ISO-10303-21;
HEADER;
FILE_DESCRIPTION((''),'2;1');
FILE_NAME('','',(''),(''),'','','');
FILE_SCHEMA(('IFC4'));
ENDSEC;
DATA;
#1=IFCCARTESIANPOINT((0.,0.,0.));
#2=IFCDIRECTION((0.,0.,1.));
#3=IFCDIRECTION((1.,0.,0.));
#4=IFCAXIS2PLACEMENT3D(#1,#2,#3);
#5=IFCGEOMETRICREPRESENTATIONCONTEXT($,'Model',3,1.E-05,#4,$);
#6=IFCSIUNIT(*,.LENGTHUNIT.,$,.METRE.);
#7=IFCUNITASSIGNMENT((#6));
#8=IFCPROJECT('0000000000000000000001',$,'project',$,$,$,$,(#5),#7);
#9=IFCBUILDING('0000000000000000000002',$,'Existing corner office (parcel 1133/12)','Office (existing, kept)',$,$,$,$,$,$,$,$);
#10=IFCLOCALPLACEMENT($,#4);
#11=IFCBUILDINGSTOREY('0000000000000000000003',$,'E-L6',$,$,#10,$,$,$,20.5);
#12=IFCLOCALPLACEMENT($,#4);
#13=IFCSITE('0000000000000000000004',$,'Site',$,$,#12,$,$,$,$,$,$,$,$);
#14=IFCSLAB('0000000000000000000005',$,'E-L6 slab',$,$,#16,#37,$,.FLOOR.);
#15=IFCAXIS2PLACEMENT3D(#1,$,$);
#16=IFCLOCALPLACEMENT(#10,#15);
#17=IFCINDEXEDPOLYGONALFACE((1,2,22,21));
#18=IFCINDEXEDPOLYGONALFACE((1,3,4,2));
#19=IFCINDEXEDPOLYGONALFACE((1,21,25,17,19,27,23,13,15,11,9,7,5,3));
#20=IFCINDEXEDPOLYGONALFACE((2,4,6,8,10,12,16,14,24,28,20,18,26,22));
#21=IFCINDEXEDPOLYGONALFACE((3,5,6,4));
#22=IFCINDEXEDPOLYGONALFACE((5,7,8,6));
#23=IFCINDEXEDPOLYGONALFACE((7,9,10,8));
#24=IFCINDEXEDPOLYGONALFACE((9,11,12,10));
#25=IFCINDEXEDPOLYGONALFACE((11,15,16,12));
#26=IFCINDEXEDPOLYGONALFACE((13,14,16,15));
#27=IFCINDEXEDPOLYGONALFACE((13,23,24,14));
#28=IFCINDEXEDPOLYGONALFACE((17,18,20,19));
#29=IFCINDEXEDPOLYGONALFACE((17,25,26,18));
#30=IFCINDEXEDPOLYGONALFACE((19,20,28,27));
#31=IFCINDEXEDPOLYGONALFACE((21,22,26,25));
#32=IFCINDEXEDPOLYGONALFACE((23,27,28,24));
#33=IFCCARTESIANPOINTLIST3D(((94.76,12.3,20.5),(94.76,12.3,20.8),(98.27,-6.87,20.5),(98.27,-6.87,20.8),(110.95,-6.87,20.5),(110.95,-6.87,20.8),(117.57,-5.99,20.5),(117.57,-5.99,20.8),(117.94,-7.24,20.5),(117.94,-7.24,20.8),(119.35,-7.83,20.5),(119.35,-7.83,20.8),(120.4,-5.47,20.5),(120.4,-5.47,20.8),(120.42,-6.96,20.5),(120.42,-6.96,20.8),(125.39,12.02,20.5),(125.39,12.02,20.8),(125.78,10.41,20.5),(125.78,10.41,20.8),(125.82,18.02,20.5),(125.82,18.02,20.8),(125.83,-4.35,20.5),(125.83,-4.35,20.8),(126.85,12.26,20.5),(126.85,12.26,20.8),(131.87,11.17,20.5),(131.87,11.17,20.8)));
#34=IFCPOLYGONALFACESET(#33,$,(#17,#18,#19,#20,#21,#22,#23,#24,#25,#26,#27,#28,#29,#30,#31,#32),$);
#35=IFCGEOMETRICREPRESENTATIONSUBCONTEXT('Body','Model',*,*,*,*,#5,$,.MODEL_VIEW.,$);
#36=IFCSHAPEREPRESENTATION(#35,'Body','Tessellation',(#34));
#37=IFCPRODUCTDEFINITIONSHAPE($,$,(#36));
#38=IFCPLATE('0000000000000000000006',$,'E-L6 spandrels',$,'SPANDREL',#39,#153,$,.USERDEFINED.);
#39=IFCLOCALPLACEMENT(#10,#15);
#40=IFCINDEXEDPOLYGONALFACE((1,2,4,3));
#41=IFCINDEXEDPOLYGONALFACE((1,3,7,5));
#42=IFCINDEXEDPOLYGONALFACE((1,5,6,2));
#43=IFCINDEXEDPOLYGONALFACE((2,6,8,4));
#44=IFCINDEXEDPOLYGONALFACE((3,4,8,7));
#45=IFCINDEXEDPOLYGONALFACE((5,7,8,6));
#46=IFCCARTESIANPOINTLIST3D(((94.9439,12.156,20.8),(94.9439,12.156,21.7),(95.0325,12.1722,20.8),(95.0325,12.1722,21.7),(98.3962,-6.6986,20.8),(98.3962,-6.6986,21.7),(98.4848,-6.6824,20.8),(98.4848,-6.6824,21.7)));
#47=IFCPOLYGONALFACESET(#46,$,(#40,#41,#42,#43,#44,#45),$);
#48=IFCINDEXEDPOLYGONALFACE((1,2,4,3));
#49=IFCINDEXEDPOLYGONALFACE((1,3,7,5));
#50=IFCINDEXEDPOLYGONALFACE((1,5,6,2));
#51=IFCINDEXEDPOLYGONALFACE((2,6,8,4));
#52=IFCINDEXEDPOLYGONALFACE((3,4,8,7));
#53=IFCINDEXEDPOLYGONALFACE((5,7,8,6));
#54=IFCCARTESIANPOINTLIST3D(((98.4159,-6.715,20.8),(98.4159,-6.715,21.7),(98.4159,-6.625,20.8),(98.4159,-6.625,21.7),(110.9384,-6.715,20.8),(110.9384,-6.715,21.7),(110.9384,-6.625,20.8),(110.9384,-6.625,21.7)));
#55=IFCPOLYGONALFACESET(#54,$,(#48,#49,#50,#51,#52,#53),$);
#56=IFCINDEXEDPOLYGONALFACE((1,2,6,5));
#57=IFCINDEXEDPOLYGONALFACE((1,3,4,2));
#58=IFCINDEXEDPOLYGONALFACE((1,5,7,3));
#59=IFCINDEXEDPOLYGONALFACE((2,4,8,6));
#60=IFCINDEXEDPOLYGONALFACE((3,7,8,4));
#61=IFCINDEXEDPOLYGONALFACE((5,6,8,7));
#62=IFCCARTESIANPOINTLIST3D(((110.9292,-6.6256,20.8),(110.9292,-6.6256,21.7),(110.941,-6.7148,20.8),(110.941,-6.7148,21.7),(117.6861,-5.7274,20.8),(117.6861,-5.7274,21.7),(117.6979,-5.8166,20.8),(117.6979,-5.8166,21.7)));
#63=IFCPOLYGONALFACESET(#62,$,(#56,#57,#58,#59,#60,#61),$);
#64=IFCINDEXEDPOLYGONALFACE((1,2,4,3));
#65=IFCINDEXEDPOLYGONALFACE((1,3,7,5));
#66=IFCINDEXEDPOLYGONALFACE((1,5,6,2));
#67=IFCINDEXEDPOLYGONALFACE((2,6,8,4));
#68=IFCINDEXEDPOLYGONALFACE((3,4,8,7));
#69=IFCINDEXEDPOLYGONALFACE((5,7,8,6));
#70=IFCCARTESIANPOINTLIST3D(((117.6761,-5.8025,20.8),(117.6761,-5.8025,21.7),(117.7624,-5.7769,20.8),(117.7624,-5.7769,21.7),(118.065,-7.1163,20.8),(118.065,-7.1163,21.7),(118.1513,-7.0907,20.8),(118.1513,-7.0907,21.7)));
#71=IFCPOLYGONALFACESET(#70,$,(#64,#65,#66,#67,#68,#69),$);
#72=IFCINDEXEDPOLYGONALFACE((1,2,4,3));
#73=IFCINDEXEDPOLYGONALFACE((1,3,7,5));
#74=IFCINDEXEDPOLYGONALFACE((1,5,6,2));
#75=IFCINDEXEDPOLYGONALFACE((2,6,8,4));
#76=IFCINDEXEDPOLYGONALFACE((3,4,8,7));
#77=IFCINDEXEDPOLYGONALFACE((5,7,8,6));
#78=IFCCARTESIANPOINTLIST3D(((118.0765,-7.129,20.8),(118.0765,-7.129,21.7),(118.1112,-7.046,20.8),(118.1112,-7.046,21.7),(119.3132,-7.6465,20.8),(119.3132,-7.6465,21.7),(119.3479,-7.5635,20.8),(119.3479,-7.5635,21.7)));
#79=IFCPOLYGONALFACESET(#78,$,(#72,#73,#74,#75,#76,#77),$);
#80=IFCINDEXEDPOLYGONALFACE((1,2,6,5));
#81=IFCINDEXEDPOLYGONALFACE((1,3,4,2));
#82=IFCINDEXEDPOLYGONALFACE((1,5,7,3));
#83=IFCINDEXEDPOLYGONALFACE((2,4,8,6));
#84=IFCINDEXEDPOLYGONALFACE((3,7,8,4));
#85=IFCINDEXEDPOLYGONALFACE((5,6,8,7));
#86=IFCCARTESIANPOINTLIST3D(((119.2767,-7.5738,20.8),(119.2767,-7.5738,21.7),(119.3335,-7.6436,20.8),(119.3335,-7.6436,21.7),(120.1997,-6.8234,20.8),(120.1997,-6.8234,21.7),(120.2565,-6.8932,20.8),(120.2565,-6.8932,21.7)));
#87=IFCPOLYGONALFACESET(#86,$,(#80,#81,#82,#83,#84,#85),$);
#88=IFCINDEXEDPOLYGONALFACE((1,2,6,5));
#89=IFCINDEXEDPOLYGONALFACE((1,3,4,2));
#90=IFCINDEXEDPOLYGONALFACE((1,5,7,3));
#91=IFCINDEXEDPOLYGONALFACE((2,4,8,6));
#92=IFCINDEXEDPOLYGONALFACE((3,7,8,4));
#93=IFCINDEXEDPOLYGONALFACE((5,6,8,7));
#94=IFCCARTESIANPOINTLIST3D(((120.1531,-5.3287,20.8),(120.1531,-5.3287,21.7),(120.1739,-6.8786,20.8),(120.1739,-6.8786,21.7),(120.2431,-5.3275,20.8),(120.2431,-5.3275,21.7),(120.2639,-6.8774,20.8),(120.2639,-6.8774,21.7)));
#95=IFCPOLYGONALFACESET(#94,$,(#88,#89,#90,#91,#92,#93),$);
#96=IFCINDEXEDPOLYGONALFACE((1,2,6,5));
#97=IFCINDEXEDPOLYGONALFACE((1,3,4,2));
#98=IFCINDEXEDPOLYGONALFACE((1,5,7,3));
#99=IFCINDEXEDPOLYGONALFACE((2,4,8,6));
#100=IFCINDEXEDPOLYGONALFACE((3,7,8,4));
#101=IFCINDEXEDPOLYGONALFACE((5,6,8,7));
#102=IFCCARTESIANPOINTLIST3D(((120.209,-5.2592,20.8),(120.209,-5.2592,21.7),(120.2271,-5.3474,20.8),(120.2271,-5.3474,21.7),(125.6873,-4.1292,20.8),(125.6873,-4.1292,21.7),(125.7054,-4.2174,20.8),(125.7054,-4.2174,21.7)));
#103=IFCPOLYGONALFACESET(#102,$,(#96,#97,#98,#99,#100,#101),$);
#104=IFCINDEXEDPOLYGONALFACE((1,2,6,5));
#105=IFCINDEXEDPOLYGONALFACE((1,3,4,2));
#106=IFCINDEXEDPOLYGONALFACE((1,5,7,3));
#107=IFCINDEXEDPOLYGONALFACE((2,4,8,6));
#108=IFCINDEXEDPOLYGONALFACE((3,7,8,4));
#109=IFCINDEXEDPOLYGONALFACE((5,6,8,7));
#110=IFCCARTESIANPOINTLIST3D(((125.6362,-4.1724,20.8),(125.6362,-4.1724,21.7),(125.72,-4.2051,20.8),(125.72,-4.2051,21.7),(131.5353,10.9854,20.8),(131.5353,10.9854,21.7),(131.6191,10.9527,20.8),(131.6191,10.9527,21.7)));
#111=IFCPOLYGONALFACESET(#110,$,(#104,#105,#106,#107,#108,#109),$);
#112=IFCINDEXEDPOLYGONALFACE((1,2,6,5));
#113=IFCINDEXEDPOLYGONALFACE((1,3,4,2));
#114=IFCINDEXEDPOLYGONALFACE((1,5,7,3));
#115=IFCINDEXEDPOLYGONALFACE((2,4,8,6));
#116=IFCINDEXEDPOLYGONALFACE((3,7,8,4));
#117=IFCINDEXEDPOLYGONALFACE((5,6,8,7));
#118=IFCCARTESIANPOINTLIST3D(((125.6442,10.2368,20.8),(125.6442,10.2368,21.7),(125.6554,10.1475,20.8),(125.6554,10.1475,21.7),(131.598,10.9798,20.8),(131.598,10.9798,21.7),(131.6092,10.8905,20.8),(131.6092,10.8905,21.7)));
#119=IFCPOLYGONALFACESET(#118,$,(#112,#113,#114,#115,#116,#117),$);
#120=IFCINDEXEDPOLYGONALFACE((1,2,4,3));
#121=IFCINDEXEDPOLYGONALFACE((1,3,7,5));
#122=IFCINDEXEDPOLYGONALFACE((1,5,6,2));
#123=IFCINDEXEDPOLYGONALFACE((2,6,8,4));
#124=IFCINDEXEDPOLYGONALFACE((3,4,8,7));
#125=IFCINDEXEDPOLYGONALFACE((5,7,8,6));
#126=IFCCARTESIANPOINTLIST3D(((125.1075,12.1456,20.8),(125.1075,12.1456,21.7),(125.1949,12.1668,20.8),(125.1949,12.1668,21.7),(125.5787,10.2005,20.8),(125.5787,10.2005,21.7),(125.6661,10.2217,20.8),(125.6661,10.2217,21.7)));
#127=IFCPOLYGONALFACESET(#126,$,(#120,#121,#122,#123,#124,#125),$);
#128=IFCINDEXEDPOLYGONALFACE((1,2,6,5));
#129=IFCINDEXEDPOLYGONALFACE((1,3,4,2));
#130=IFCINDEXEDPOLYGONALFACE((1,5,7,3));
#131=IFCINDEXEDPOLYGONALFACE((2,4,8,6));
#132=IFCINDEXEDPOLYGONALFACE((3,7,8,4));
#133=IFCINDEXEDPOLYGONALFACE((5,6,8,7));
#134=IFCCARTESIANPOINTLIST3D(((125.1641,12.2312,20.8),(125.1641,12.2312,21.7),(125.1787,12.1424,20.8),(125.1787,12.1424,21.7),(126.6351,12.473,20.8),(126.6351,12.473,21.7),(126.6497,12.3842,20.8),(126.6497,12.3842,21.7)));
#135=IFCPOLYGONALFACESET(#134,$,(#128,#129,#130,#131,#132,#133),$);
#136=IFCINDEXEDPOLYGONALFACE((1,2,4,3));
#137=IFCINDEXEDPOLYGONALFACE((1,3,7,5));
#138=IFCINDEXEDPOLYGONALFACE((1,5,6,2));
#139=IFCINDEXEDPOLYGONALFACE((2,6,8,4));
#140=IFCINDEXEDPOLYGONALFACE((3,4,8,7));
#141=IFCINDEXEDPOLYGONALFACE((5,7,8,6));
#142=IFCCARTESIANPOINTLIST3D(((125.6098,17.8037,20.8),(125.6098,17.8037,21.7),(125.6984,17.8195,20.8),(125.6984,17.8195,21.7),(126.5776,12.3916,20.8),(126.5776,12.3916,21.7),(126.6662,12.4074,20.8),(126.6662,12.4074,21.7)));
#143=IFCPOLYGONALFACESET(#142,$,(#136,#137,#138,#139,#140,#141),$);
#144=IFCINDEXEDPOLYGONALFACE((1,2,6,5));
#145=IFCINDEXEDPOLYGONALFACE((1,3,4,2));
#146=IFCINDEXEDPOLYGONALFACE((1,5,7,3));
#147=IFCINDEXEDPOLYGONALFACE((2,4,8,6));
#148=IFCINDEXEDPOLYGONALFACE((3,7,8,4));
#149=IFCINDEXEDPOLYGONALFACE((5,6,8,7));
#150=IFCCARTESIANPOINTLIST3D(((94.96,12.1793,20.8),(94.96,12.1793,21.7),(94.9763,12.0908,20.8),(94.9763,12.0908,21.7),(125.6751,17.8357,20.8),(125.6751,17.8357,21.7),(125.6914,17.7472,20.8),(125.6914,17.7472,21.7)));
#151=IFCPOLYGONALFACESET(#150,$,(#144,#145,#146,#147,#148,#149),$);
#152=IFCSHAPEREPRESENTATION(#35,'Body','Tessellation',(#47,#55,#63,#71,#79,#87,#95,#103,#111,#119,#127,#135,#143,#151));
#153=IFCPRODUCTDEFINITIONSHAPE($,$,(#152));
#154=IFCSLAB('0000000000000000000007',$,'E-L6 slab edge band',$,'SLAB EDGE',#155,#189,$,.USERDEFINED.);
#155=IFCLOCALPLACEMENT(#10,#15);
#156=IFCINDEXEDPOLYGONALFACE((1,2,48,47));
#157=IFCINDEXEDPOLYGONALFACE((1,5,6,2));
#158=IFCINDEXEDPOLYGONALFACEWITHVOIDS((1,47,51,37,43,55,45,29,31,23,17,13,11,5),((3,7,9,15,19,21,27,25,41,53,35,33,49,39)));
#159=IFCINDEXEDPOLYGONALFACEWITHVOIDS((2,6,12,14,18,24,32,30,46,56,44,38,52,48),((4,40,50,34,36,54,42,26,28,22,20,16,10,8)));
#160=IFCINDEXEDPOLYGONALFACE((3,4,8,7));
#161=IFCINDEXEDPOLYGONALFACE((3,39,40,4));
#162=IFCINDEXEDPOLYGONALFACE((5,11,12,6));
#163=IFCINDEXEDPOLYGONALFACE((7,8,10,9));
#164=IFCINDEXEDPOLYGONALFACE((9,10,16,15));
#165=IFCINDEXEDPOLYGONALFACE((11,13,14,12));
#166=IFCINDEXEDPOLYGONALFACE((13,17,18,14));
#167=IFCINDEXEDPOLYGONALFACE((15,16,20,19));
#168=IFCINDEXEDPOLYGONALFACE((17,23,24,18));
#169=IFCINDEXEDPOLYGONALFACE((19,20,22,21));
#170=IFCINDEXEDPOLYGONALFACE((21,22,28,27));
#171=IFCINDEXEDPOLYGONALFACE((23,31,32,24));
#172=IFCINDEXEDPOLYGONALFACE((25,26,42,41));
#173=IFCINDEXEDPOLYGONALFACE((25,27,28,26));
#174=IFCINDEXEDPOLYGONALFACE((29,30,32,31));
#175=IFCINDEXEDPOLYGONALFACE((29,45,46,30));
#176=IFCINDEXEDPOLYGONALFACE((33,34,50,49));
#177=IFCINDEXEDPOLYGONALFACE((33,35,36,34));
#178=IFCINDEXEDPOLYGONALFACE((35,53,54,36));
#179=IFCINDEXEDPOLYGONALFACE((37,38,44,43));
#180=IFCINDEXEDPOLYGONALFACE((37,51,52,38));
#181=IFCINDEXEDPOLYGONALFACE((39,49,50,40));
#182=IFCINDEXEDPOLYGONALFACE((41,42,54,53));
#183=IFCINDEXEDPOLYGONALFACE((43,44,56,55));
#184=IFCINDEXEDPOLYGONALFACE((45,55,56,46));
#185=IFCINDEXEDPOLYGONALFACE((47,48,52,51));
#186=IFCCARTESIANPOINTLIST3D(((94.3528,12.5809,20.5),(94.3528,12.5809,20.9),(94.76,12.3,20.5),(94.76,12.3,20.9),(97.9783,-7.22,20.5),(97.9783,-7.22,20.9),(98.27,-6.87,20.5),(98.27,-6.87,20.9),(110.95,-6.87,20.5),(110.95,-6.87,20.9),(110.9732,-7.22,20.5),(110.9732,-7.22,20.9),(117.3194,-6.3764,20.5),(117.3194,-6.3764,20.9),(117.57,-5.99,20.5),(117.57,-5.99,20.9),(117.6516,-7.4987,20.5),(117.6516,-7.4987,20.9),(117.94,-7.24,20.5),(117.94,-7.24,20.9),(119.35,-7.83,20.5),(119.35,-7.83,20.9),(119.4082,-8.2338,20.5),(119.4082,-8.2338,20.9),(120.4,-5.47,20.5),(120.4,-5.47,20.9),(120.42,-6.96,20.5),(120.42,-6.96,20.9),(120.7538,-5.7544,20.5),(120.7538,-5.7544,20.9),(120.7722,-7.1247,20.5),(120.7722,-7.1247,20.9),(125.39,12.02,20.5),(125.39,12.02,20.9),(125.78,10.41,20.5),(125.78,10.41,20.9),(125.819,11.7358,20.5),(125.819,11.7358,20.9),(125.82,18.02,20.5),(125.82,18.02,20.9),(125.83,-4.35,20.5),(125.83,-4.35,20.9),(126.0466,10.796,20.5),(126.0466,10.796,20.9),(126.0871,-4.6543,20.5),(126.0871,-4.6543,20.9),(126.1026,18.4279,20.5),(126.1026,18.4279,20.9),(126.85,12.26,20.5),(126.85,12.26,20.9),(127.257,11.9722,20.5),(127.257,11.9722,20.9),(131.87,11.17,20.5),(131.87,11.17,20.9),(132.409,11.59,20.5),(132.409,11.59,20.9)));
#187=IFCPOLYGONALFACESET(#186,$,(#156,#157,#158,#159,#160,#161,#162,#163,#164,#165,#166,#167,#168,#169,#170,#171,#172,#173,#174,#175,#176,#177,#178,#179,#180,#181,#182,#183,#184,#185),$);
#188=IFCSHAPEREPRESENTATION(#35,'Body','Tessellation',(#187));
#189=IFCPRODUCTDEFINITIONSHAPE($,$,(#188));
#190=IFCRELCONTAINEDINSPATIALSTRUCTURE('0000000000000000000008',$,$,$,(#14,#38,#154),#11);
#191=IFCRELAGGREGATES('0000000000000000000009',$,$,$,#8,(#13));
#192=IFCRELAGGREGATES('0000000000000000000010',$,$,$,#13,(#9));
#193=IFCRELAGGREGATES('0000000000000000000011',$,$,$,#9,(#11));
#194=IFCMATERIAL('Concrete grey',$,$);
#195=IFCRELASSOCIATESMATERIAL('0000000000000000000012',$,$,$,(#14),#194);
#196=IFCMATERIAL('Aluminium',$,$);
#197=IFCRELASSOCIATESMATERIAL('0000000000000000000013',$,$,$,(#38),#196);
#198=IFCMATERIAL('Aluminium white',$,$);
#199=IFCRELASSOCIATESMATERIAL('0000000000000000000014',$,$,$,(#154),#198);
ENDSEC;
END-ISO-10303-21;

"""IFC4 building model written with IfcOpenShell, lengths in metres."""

from ifc_helpers import new_model, si_unit, frame, origin_with_axes, place, context, subcontext, project, spatial, polyline, outline, extrude, material, element, save


model = new_model("IFC4")

# Units and contexts
model_context = context("Model", 3, precision=1e-05, world=origin_with_axes())
body_context = subcontext(model_context, "Body", "Model", "MODEL_VIEW")
ifc_project = project(units=[si_unit("LENGTHUNIT", "METRE")], contexts=[model_context])

# Site, building, storey
site_placement = place(None, origin_with_axes())
site = spatial("IfcSite", under=ifc_project, at=site_placement, Name="Site")
building = spatial("IfcBuilding", under=site, Name="Existing corner office (parcel 1133/12)", Description="Office (existing, kept)")
storey_placement = place(None, origin_with_axes())
storey = spatial("IfcBuildingStorey", under=building, at=storey_placement, Name="E-L6", Elevation=20.5)

# Shared definitions
ifc_material_1 = material(Name="Aluminium")

# Slab
ifc_material_2 = material(Name="Concrete grey")
slab_1_placement = place(storey_placement, origin_with_axes())
element("IfcSlab", 1, at=slab_1_placement, inside=storey, material=ifc_material_2, Name="E-L6 slab", PredefinedType="FLOOR", context=body_context, shape_type="SweptSolid", body=[
    extrude(outline(polyline([(94.76, 12.3), (98.27, -6.87), (110.95, -6.87), (117.57, -5.99), (117.94, -7.24), (119.35, -7.83), (120.42, -6.96), (120.4, -5.47), (125.83, -4.35), (131.87, 11.17), (125.78, 10.41), (125.39, 12.02), (126.85, 12.26), (125.82, 18.02), (94.76, 12.3)])), frame((0.0, 0.0, 20.5), z_axis=(0.0, 0.0, 1.0), x_axis=(1.0, 0.0, 0.0)), (0.0, 0.0, 1.0), 0.3),
])

# Plate
plate_placement = place(storey_placement, origin_with_axes())
element("IfcPlate", 2, at=plate_placement, inside=storey, material=ifc_material_1, Name="E-L6 spandrels", ObjectType="SPANDREL", PredefinedType="USERDEFINED", context=body_context, shape_type="SweptSolid", body=[
    extrude(outline(polyline([(94.9439, 12.156), (98.3962, -6.6986), (98.4848, -6.6824), (95.0325, 12.1722), (94.9439, 12.156)])), frame((0.0, 0.0, 20.8), z_axis=(0.0, 0.0, 1.0), x_axis=(1.0, 0.0, 0.0)), (0.0, 0.0, 1.0), 0.9),
    extrude(outline(polyline([(98.4159, -6.715), (110.9384, -6.715), (110.9384, -6.625), (98.4159, -6.625), (98.4159, -6.715)])), frame((0.0, 0.0, 20.8), z_axis=(0.0, 0.0, 1.0), x_axis=(1.0, 0.0, 0.0)), (0.0, 0.0, 1.0), 0.9),
    extrude(outline(polyline([(110.941, -6.7148), (117.6979, -5.8166), (117.6861, -5.7274), (110.9292, -6.6256), (110.941, -6.7148)])), frame((0.0, 0.0, 20.8), z_axis=(0.0, 0.0, 1.0), x_axis=(1.0, 0.0, 0.0)), (0.0, 0.0, 1.0), 0.9),
    extrude(outline(polyline([(117.6761, -5.8025), (118.065, -7.1163), (118.1513, -7.0907), (117.7624, -5.7769), (117.6761, -5.8025)])), frame((0.0, 0.0, 20.8), z_axis=(0.0, 0.0, 1.0), x_axis=(1.0, 0.0, 0.0)), (0.0, 0.0, 1.0), 0.9),
    extrude(outline(polyline([(118.0765, -7.129), (119.3132, -7.6465), (119.3479, -7.5635), (118.1112, -7.046), (118.0765, -7.129)])), frame((0.0, 0.0, 20.8), z_axis=(0.0, 0.0, 1.0), x_axis=(1.0, 0.0, 0.0)), (0.0, 0.0, 1.0), 0.9),
    extrude(outline(polyline([(119.3335, -7.6436), (120.2565, -6.8932), (120.1997, -6.8234), (119.2767, -7.5738), (119.3335, -7.6436)])), frame((0.0, 0.0, 20.8), z_axis=(0.0, 0.0, 1.0), x_axis=(1.0, 0.0, 0.0)), (0.0, 0.0, 1.0), 0.9),
    extrude(outline(polyline([(120.2639, -6.8774), (120.2431, -5.3275), (120.1531, -5.3287), (120.1739, -6.8786), (120.2639, -6.8774)])), frame((0.0, 0.0, 20.8), z_axis=(0.0, 0.0, 1.0), x_axis=(1.0, 0.0, 0.0)), (0.0, 0.0, 1.0), 0.9),
    extrude(outline(polyline([(120.2271, -5.3474), (125.7054, -4.2174), (125.6873, -4.1292), (120.209, -5.2592), (120.2271, -5.3474)])), frame((0.0, 0.0, 20.8), z_axis=(0.0, 0.0, 1.0), x_axis=(1.0, 0.0, 0.0)), (0.0, 0.0, 1.0), 0.9),
    extrude(outline(polyline([(125.72, -4.2051), (131.6191, 10.9527), (131.5353, 10.9854), (125.6362, -4.1724), (125.72, -4.2051)])), frame((0.0, 0.0, 20.8), z_axis=(0.0, 0.0, 1.0), x_axis=(1.0, 0.0, 0.0)), (0.0, 0.0, 1.0), 0.9),
    extrude(outline(polyline([(131.598, 10.9798), (125.6442, 10.2368), (125.6554, 10.1475), (131.6092, 10.8905), (131.598, 10.9798)])), frame((0.0, 0.0, 20.8), z_axis=(0.0, 0.0, 1.0), x_axis=(1.0, 0.0, 0.0)), (0.0, 0.0, 1.0), 0.9),
    extrude(outline(polyline([(125.6661, 10.2217), (125.1949, 12.1668), (125.1075, 12.1456), (125.5787, 10.2005), (125.6661, 10.2217)])), frame((0.0, 0.0, 20.8), z_axis=(0.0, 0.0, 1.0), x_axis=(1.0, 0.0, 0.0)), (0.0, 0.0, 1.0), 0.9),
    extrude(outline(polyline([(125.1787, 12.1424), (126.6497, 12.3842), (126.6351, 12.473), (125.1641, 12.2312), (125.1787, 12.1424)])), frame((0.0, 0.0, 20.8), z_axis=(0.0, 0.0, 1.0), x_axis=(1.0, 0.0, 0.0)), (0.0, 0.0, 1.0), 0.9),
    extrude(outline(polyline([(126.6662, 12.4074), (125.6984, 17.8195), (125.6098, 17.8037), (126.5776, 12.3916), (126.6662, 12.4074)])), frame((0.0, 0.0, 20.8), z_axis=(0.0, 0.0, 1.0), x_axis=(1.0, 0.0, 0.0)), (0.0, 0.0, 1.0), 0.9),
    extrude(outline(polyline([(125.6751, 17.8357), (94.96, 12.1793), (94.9763, 12.0908), (125.6914, 17.7472), (125.6751, 17.8357)])), frame((0.0, 0.0, 20.8), z_axis=(0.0, 0.0, 1.0), x_axis=(1.0, 0.0, 0.0)), (0.0, 0.0, 1.0), 0.9),
])

# Slab
ifc_material_3 = material(Name="Aluminium white")
slab_2_placement = place(storey_placement, origin_with_axes())
element("IfcSlab", 3, at=slab_2_placement, inside=storey, material=ifc_material_3, Name="E-L6 slab edge band", ObjectType="SLAB EDGE", PredefinedType="USERDEFINED", context=body_context, shape_type="SweptSolid", body=[
    extrude(outline(polyline([(94.3528, 12.5809), (97.9783, -7.22), (110.9732, -7.22), (117.3194, -6.3764), (117.6516, -7.4987), (119.4082, -8.2338), (120.7722, -7.1247), (120.7538, -5.7544), (126.0871, -4.6543), (132.409, 11.59), (126.0466, 10.796), (125.819, 11.7358), (127.257, 11.9722), (126.1026, 18.4279), (94.3528, 12.5809)]), holes=[polyline([(94.76, 12.3), (98.27, -6.87), (110.95, -6.87), (117.57, -5.99), (117.94, -7.24), (119.35, -7.83), (120.42, -6.96), (120.4, -5.47), (125.83, -4.35), (131.87, 11.17), (125.78, 10.41), (125.39, 12.02), (126.85, 12.26), (125.82, 18.02), (94.76, 12.3)])]), frame((0.0, 0.0, 20.5), z_axis=(0.0, 0.0, 1.0), x_axis=(1.0, 0.0, 0.0)), (0.0, 0.0, 1.0), 0.4),
])

save(model, "model.ifc")
